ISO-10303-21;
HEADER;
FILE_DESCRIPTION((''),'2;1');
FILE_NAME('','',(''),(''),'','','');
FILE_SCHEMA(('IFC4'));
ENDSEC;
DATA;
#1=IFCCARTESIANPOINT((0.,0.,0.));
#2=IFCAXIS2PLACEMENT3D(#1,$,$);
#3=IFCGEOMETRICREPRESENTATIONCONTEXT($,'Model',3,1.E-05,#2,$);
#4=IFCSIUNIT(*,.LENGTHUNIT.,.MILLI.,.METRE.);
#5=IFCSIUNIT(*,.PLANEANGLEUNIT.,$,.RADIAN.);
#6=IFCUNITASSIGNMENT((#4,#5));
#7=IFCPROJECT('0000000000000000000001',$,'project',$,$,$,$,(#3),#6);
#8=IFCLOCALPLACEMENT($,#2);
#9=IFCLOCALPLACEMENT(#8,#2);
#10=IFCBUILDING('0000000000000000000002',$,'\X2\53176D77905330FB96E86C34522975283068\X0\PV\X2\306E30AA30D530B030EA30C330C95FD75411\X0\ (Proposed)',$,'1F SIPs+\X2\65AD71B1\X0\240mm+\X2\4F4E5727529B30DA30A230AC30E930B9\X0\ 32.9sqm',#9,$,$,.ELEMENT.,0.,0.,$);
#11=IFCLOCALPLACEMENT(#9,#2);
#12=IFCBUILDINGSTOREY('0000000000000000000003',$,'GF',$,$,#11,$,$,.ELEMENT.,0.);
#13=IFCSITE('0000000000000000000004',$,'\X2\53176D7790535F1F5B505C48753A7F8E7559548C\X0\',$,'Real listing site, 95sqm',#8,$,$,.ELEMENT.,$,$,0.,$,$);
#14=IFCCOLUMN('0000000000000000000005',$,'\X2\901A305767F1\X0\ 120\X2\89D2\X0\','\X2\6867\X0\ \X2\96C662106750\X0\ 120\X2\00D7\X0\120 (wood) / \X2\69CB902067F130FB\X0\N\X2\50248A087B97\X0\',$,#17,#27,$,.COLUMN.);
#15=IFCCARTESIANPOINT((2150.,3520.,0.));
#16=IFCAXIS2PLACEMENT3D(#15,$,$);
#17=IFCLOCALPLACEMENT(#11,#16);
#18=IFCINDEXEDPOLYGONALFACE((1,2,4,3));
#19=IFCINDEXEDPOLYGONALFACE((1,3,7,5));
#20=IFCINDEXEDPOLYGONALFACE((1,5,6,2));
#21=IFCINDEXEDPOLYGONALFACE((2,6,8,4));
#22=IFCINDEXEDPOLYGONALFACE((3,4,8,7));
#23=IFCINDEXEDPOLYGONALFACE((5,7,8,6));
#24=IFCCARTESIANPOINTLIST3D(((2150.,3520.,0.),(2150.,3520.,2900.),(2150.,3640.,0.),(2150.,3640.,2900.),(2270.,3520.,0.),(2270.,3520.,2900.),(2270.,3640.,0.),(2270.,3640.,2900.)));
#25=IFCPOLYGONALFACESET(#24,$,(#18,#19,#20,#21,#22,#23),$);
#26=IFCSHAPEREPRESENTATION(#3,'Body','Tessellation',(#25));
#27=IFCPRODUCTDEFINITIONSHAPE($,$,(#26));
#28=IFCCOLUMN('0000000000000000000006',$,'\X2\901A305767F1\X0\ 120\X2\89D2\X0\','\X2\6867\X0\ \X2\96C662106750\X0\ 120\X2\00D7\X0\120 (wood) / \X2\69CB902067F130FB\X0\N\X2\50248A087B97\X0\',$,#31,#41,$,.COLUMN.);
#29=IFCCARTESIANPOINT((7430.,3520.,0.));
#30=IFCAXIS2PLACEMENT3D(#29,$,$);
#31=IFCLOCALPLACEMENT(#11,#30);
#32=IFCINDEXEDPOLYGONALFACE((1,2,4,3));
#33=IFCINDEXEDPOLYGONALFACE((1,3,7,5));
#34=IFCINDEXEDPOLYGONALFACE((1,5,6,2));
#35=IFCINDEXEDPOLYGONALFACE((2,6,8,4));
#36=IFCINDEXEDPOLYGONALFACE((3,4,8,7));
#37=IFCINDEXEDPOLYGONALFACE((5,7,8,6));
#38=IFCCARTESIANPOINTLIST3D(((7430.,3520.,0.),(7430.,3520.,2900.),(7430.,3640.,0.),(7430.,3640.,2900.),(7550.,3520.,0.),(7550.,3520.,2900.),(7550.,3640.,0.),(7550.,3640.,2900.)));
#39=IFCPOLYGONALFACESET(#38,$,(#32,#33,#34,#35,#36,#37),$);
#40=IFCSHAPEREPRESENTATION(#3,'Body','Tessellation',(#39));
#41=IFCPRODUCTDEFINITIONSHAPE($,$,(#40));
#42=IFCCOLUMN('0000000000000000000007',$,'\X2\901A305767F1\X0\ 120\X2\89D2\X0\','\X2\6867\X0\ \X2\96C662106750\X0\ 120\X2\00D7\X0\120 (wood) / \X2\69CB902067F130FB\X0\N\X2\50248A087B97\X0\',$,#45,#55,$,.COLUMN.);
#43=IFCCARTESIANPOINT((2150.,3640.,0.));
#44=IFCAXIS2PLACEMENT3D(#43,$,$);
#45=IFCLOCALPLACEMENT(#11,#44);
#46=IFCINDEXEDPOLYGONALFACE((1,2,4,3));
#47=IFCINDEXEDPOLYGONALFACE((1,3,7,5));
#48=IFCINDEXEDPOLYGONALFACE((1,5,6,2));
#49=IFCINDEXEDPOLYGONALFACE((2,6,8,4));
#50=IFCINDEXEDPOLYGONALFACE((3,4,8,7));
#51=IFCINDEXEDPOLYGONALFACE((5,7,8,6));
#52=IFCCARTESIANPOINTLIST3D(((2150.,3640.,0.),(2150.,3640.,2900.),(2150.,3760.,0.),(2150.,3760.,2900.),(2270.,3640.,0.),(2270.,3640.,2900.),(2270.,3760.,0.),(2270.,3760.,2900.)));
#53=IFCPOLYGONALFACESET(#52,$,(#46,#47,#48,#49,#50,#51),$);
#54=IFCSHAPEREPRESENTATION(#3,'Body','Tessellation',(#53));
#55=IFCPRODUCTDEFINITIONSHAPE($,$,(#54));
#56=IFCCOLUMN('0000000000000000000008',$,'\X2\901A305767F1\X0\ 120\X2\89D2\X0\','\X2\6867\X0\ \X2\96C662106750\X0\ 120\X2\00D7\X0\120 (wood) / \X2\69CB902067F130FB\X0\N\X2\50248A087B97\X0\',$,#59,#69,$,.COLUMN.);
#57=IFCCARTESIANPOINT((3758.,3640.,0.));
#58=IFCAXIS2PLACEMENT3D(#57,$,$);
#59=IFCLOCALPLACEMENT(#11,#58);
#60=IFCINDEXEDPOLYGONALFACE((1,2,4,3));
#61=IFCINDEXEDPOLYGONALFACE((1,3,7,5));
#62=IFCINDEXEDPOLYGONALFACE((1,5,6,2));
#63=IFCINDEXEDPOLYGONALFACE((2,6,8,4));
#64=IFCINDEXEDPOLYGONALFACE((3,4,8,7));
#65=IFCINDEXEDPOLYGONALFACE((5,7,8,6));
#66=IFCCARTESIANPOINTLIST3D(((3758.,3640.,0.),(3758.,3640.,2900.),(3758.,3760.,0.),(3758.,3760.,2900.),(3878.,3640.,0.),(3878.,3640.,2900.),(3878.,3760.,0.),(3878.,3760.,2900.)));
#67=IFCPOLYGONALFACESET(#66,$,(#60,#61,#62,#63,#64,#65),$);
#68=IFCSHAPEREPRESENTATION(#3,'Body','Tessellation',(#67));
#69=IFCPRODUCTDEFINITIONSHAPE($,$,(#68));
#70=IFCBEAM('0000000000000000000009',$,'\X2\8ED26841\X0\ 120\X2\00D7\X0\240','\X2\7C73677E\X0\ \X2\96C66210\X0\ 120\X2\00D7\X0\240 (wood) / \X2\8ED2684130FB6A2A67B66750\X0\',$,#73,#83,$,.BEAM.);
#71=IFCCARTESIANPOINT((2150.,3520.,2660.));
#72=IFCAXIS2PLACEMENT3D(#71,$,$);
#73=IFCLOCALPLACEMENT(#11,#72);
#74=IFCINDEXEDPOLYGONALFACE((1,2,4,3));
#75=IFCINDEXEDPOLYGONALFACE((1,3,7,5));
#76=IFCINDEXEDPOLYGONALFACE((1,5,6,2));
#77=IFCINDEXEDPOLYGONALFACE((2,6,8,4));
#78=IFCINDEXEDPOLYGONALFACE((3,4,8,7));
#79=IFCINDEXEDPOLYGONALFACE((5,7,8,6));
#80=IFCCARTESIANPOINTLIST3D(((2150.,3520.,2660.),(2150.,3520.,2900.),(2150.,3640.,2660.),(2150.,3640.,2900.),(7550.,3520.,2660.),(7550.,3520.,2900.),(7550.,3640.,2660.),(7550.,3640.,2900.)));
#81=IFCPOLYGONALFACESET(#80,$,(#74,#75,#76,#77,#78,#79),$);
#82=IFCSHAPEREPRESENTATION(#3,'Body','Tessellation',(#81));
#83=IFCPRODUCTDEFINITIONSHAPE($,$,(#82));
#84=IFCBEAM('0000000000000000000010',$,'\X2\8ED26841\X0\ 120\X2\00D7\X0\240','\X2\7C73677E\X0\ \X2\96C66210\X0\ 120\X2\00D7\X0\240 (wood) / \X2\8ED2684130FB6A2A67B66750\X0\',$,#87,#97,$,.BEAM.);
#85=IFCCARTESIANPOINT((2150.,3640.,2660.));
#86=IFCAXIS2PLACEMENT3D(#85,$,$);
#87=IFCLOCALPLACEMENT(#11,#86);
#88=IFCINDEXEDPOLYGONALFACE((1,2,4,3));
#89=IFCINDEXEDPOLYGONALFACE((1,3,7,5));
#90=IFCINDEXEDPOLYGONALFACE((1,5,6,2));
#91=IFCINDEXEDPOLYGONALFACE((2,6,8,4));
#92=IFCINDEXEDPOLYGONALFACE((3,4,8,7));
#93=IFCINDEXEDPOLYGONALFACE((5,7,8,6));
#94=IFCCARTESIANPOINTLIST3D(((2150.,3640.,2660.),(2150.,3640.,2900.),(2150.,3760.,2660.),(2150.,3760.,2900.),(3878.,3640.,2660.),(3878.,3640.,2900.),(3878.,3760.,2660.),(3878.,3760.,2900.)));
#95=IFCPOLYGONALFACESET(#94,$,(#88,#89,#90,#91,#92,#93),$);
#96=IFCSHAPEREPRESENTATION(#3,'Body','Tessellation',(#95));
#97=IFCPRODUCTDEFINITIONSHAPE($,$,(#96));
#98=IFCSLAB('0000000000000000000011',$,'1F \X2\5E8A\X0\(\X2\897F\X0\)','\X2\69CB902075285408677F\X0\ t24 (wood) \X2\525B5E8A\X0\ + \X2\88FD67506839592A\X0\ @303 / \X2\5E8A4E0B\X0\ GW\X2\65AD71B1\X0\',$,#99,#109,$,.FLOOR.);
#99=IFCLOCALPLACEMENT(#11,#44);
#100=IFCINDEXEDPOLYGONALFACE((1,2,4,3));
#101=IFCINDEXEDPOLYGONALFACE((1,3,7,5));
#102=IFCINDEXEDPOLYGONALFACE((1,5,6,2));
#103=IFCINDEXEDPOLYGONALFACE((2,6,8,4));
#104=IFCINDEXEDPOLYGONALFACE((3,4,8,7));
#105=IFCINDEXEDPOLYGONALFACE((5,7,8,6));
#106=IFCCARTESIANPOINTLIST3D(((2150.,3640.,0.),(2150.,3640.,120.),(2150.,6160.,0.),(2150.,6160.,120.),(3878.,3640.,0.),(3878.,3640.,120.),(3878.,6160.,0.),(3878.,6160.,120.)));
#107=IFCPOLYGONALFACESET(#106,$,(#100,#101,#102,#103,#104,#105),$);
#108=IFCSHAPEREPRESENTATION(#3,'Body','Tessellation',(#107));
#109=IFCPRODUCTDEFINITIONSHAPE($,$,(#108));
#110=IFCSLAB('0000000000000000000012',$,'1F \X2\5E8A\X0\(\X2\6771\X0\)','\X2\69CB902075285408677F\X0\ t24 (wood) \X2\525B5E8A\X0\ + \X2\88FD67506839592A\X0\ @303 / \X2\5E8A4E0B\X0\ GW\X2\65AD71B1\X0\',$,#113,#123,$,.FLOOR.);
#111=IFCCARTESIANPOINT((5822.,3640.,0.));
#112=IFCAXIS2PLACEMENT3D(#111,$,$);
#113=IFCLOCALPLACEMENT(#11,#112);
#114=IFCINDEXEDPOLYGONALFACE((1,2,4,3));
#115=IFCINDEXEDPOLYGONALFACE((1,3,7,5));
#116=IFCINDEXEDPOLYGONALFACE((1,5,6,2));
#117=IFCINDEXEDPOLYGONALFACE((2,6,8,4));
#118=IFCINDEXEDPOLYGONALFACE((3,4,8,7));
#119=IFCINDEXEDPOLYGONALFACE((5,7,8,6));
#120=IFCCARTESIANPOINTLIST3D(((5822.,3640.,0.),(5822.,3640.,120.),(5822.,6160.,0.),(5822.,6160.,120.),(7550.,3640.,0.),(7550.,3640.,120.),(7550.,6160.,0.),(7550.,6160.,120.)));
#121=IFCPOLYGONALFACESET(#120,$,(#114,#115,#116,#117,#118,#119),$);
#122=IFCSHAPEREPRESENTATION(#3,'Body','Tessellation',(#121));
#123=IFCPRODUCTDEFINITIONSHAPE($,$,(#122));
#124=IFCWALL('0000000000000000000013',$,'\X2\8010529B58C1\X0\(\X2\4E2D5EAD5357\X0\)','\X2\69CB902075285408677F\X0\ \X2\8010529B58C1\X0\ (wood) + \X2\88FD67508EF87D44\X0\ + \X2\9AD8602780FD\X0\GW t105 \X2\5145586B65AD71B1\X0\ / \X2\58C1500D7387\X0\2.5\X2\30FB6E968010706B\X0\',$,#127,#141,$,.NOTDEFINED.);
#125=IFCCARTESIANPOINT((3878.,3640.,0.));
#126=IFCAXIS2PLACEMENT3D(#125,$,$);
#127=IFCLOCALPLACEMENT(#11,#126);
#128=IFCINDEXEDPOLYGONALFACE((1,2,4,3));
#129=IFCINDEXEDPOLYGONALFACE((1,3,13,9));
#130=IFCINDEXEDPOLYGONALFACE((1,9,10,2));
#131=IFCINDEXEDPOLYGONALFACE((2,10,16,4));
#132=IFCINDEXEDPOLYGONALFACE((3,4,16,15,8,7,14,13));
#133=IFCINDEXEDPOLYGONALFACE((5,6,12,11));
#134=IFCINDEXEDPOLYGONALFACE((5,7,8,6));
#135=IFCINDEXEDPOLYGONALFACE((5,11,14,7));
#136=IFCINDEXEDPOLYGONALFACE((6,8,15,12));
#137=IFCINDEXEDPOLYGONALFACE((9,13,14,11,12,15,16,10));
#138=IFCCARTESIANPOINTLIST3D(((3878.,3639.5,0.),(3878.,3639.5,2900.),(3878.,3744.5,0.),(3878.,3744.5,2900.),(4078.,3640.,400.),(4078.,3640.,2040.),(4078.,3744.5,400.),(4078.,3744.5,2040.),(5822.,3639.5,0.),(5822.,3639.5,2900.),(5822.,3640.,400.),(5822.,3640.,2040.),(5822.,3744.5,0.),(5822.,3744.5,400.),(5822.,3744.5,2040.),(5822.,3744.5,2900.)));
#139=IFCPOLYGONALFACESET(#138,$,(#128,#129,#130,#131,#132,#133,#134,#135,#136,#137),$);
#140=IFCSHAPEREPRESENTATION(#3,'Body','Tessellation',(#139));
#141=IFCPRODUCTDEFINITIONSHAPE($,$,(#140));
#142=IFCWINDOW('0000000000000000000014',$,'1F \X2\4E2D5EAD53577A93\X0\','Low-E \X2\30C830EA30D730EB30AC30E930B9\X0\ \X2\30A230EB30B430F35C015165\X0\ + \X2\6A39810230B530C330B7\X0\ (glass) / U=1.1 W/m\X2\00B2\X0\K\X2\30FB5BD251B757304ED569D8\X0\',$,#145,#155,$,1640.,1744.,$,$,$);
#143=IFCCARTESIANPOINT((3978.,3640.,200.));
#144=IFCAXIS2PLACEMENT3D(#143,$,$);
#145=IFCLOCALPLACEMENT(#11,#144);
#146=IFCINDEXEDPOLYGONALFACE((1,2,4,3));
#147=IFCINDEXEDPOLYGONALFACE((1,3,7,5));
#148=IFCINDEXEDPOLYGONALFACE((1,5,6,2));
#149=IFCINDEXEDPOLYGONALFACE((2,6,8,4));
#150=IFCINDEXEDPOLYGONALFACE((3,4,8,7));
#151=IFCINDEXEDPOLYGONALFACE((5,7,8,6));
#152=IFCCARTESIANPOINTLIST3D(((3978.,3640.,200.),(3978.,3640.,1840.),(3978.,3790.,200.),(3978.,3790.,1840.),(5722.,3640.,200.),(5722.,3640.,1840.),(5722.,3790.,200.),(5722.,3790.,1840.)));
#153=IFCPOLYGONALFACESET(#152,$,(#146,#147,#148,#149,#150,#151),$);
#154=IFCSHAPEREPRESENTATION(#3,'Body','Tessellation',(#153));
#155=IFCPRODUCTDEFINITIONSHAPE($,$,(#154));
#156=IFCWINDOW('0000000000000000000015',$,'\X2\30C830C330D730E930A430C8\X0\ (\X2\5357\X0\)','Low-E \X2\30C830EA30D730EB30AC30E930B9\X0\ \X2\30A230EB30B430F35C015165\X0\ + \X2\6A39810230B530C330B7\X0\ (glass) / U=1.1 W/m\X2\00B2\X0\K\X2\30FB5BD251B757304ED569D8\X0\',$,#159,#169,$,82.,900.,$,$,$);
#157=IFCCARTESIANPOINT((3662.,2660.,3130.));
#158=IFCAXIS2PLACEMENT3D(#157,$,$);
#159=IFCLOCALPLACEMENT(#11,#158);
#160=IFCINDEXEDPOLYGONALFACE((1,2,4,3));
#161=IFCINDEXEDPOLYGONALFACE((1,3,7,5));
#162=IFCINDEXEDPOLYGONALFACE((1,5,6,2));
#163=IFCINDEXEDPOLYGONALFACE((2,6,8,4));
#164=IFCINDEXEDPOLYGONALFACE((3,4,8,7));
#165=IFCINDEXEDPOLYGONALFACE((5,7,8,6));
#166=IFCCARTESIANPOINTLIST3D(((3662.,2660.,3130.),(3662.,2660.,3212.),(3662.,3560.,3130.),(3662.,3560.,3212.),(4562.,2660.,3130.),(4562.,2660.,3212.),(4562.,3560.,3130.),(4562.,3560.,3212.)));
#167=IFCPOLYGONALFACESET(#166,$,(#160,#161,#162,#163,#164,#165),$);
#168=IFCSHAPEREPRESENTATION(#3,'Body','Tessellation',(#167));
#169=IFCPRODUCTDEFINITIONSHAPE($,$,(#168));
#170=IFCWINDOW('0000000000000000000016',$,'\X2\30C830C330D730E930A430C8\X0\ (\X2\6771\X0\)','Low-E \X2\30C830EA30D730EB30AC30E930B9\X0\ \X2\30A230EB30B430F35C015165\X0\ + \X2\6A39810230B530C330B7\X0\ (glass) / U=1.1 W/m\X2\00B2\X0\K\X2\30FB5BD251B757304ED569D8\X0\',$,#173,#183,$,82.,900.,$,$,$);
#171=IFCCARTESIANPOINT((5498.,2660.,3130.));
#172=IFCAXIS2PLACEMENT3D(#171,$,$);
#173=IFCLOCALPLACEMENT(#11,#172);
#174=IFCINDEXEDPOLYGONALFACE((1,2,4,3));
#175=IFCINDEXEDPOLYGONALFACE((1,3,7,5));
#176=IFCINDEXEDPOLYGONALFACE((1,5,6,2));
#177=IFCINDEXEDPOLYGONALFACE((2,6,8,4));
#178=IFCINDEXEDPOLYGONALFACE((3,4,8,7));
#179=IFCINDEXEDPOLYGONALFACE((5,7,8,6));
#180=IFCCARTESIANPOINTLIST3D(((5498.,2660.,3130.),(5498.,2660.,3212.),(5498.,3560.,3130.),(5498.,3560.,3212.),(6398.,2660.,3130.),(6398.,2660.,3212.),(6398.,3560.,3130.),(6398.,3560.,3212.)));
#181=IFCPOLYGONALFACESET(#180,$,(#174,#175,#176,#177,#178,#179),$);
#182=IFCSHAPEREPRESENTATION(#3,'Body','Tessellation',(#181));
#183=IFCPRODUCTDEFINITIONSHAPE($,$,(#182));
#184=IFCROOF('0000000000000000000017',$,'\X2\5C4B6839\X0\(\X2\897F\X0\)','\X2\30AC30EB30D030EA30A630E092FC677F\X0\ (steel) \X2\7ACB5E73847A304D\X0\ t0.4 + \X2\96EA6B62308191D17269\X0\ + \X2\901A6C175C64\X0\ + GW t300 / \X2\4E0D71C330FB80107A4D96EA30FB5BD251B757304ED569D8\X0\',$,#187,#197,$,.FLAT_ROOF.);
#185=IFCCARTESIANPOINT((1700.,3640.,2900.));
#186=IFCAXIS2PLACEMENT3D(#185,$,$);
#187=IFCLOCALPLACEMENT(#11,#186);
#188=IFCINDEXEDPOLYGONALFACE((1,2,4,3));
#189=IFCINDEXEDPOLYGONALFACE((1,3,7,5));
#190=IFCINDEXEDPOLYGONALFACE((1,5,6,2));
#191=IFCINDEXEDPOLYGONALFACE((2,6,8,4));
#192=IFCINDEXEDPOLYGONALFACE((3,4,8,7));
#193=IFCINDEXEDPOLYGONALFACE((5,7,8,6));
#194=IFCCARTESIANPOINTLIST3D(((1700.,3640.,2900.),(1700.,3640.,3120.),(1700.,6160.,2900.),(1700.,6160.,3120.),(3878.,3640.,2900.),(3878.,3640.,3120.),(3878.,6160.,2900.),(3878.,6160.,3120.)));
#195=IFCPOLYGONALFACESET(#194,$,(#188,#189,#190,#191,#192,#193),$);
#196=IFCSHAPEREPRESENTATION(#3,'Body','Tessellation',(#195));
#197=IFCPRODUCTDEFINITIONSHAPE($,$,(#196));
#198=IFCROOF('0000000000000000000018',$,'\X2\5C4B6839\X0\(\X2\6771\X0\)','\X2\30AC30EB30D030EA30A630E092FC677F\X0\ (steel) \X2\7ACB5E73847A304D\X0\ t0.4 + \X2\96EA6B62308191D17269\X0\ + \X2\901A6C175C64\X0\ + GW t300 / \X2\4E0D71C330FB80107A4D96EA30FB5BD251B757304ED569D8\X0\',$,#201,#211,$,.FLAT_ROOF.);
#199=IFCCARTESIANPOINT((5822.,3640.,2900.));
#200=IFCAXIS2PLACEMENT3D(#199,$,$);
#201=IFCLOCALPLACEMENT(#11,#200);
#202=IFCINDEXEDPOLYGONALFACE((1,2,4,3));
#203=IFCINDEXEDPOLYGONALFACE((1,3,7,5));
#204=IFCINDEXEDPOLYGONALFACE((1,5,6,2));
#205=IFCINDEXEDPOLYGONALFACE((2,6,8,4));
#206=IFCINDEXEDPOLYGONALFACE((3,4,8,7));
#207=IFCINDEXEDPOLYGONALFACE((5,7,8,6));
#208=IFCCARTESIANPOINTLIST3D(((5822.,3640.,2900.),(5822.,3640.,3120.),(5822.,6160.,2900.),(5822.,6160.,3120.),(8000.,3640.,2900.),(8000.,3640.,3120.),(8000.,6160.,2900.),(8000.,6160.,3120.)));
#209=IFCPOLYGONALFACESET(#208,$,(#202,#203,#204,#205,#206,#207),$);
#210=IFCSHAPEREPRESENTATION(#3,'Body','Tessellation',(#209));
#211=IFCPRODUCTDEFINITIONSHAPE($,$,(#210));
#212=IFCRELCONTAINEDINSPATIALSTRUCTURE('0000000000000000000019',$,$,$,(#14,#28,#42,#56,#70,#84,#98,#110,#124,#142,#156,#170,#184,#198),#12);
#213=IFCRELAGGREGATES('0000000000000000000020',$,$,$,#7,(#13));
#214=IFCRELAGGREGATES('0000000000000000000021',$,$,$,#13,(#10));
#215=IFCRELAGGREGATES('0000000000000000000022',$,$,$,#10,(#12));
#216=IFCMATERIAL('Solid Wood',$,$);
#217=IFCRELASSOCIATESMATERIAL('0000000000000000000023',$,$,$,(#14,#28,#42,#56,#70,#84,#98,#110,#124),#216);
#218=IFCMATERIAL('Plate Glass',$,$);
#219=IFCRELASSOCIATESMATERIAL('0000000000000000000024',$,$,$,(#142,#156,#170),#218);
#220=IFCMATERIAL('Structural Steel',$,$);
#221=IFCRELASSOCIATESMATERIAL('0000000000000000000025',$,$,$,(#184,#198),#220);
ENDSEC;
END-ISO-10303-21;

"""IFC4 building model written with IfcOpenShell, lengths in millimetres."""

from ifc_helpers import new_model, si_unit, frame, frame_2d, origin, place, context, project, spatial, rectangle, extrude, material, element, fill, save


model = new_model("IFC4")

# Units and contexts
model_context = context("Model", 3, precision=1e-05, world=origin())
ifc_project = project(units=[si_unit("LENGTHUNIT", "METRE", prefix="MILLI"), si_unit("PLANEANGLEUNIT", "RADIAN")], contexts=[model_context])

# Site, building, storey
site_placement = place(None, origin())
site = spatial("IfcSite", under=ifc_project, at=site_placement, Name="北海道弟子屈町美留和", ObjectType="Real listing site, 95sqm", CompositionType="ELEMENT", RefElevation=0.0)
building_placement = place(site_placement, origin())
building = spatial("IfcBuilding", under=site, at=building_placement, Name="北海道・雨水利用とPVのオフグリッド志向 (Proposed)", ObjectType="1F SIPs+断熱240mm+低圧力ペアガラス 32.9sqm", CompositionType="ELEMENT", ElevationOfRefHeight=0.0, ElevationOfTerrain=0.0)
storey_placement = place(building_placement, origin())
storey = spatial("IfcBuildingStorey", under=building, at=storey_placement, Name="GF", CompositionType="ELEMENT", Elevation=0.0)

# Columns
ifc_material_1 = material(Name="Solid Wood")
column_1_placement = place(storey_placement, frame((2150.0, 3520.0, 0.0)))
element("IfcColumn", 1, at=column_1_placement, inside=storey, material=ifc_material_1, Name="通し柱 120角", Description="桧 集成材 120×120 (wood) / 構造柱・N値計算", PredefinedType="COLUMN", context=model_context, shape_type="SweptSolid", body=[
    extrude(rectangle(XDim=120.0, YDim=120.0, at=frame_2d((60.0, 60.0))), frame((2150.0, 3520.0, 0.0)), (0.0, 0.0, 1.0), 2900.0),
])
column_2_placement = place(storey_placement, frame((7430.0, 3520.0, 0.0)))
element("IfcColumn", 2, at=column_2_placement, inside=storey, material=ifc_material_1, Name="通し柱 120角", Description="桧 集成材 120×120 (wood) / 構造柱・N値計算", PredefinedType="COLUMN", context=model_context, shape_type="SweptSolid", body=[
    extrude(rectangle(XDim=120.0, YDim=120.0, at=frame_2d((60.0, 60.0))), frame((7430.0, 3520.0, 0.0)), (0.0, 0.0, 1.0), 2900.0),
])
column_3_placement = place(storey_placement, frame((2150.0, 3640.0, 0.0)))
element("IfcColumn", 3, at=column_3_placement, inside=storey, material=ifc_material_1, Name="通し柱 120角", Description="桧 集成材 120×120 (wood) / 構造柱・N値計算", PredefinedType="COLUMN", context=model_context, shape_type="SweptSolid", body=[
    extrude(rectangle(XDim=120.0, YDim=120.0, at=frame_2d((60.0, 60.0))), frame((2150.0, 3640.0, 0.0)), (0.0, 0.0, 1.0), 2900.0),
])
column_4_placement = place(storey_placement, frame((3758.0, 3640.0, 0.0)))
element("IfcColumn", 4, at=column_4_placement, inside=storey, material=ifc_material_1, Name="通し柱 120角", Description="桧 集成材 120×120 (wood) / 構造柱・N値計算", PredefinedType="COLUMN", context=model_context, shape_type="SweptSolid", body=[
    extrude(rectangle(XDim=120.0, YDim=120.0, at=frame_2d((60.0, 60.0))), frame((3758.0, 3640.0, 0.0)), (0.0, 0.0, 1.0), 2900.0),
])

# Beams
beam_1_placement = place(storey_placement, frame((2150.0, 3520.0, 2660.0)))
element("IfcBeam", 5, at=beam_1_placement, inside=storey, material=ifc_material_1, Name="軒桁 120×240", Description="米松 集成 120×240 (wood) / 軒桁・横架材", PredefinedType="BEAM", context=model_context, shape_type="SweptSolid", body=[
    extrude(rectangle(XDim=5400.0, YDim=120.0, at=frame_2d((2700.0, 60.0))), frame((2150.0, 3520.0, 2660.0)), (0.0, 0.0, 1.0), 240.0),
])
beam_2_placement = place(storey_placement, frame((2150.0, 3640.0, 2660.0)))
element("IfcBeam", 6, at=beam_2_placement, inside=storey, material=ifc_material_1, Name="軒桁 120×240", Description="米松 集成 120×240 (wood) / 軒桁・横架材", PredefinedType="BEAM", context=model_context, shape_type="SweptSolid", body=[
    extrude(rectangle(XDim=1728.0, YDim=120.0, at=frame_2d((864.0, 60.0))), frame((2150.0, 3640.0, 2660.0)), (0.0, 0.0, 1.0), 240.0),
])

# Slabs
slab_1_placement = place(storey_placement, frame((2150.0, 3640.0, 0.0)))
element("IfcSlab", 7, at=slab_1_placement, inside=storey, material=ifc_material_1, Name="1F 床(西)", Description="構造用合板 t24 (wood) 剛床 + 製材根太 @303 / 床下 GW断熱", PredefinedType="FLOOR", context=model_context, shape_type="SweptSolid", body=[
    extrude(rectangle(XDim=1728.0, YDim=2520.0, at=frame_2d((864.0, 1260.0))), frame((2150.0, 3640.0, 0.0)), (0.0, 0.0, 1.0), 120.0),
])
slab_2_placement = place(storey_placement, frame((5822.0, 3640.0, 0.0)))
element("IfcSlab", 8, at=slab_2_placement, inside=storey, material=ifc_material_1, Name="1F 床(東)", Description="構造用合板 t24 (wood) 剛床 + 製材根太 @303 / 床下 GW断熱", PredefinedType="FLOOR", context=model_context, shape_type="SweptSolid", body=[
    extrude(rectangle(XDim=1728.0, YDim=2520.0, at=frame_2d((864.0, 1260.0))), frame((5822.0, 3640.0, 0.0)), (0.0, 0.0, 1.0), 120.0),
])

# Wall, opening, window
wall_1_placement = place(storey_placement, frame((3878.0, 3640.0, 0.0)))
wall_1 = element("IfcWall", 9, at=wall_1_placement, inside=storey, material=ifc_material_1, Name="耐力壁(中庭南)", Description="構造用合板 耐力壁 (wood) + 製材軸組 + 高性能GW t105 充填断熱 / 壁倍率2.5・準耐火", PredefinedType="NOTDEFINED", context=model_context, shape_type="SweptSolid", body=[
    extrude(rectangle(XDim=1944.0, YDim=105.0, at=frame_2d((972.0, 52.0))), frame((3878.0, 3640.0, 0.0)), (0.0, 0.0, 1.0), 2900.0),
])
opening_placement = place(storey_placement, frame((3978.0, 3640.0, 200.0)))
opening = element("IfcOpeningElement", 10, at=opening_placement, cuts=wall_1, PredefinedType="NOTDEFINED", context=model_context, shape_type="SweptSolid", body=[
    extrude(rectangle(XDim=1744.0, YDim=150.0, at=frame_2d((872.0, 75.0))), frame((3978.0, 3640.0, 200.0)), (0.0, 0.0, 1.0), 1640.0),
])
ifc_material_2 = material(Name="Plate Glass")
window_1_placement = place(storey_placement, frame((3978.0, 3640.0, 200.0)))
window_1 = element("IfcWindow", 11, at=window_1_placement, inside=storey, material=ifc_material_2, Name="1F 中庭南窓", Description="Low-E トリプルガラス アルゴン封入 + 樹脂サッシ (glass) / U=1.1 W/m²K・寒冷地仕様", OverallHeight=1640.0, OverallWidth=1744.0, context=model_context, shape_type="SweptSolid", body=[
    extrude(rectangle(XDim=1744.0, YDim=150.0, at=frame_2d((872.0, 75.0))), frame((3978.0, 3640.0, 200.0)), (0.0, 0.0, 1.0), 1640.0),
])
fill(opening, window_1)

# Windows
window_2_placement = place(storey_placement, frame((3662.0, 2660.0, 3130.0)))
element("IfcWindow", 12, at=window_2_placement, inside=storey, material=ifc_material_2, Name="トップライト (南)", Description="Low-E トリプルガラス アルゴン封入 + 樹脂サッシ (glass) / U=1.1 W/m²K・寒冷地仕様", OverallHeight=82.0, OverallWidth=900.0, context=model_context, shape_type="SweptSolid", body=[
    extrude(rectangle(XDim=900.0, YDim=900.0, at=frame_2d((450.0, 450.0))), frame((3662.0, 2660.0, 3130.0)), (0.0, 0.0, 1.0), 82.0),
])
window_3_placement = place(storey_placement, frame((5498.0, 2660.0, 3130.0)))
element("IfcWindow", 13, at=window_3_placement, inside=storey, material=ifc_material_2, Name="トップライト (東)", Description="Low-E トリプルガラス アルゴン封入 + 樹脂サッシ (glass) / U=1.1 W/m²K・寒冷地仕様", OverallHeight=82.0, OverallWidth=900.0, context=model_context, shape_type="SweptSolid", body=[
    extrude(rectangle(XDim=900.0, YDim=900.0, at=frame_2d((450.0, 450.0))), frame((5498.0, 2660.0, 3130.0)), (0.0, 0.0, 1.0), 82.0),
])

# Roofs
ifc_material_3 = material(Name="Structural Steel")
roof_1_placement = place(storey_placement, frame((1700.0, 3640.0, 2900.0)))
element("IfcRoof", 14, at=roof_1_placement, inside=storey, material=ifc_material_3, Name="屋根(西)", Description="ガルバリウム鋼板 (steel) 立平葺き t0.4 + 雪止め金物 + 通気層 + GW t300 / 不燃・耐積雪・寒冷地仕様", PredefinedType="FLAT_ROOF", context=model_context, shape_type="SweptSolid", body=[
    extrude(rectangle(XDim=2178.0, YDim=2520.0, at=frame_2d((1089.0, 1260.0))), frame((1700.0, 3640.0, 2900.0)), (0.0, 0.0, 1.0), 220.0),
])
roof_2_placement = place(storey_placement, frame((5822.0, 3640.0, 2900.0)))
element("IfcRoof", 15, at=roof_2_placement, inside=storey, material=ifc_material_3, Name="屋根(東)", Description="ガルバリウム鋼板 (steel) 立平葺き t0.4 + 雪止め金物 + 通気層 + GW t300 / 不燃・耐積雪・寒冷地仕様", PredefinedType="FLAT_ROOF", context=model_context, shape_type="SweptSolid", body=[
    extrude(rectangle(XDim=2178.0, YDim=2520.0, at=frame_2d((1089.0, 1260.0))), frame((5822.0, 3640.0, 2900.0)), (0.0, 0.0, 1.0), 220.0),
])

save(model, "model.ifc")
